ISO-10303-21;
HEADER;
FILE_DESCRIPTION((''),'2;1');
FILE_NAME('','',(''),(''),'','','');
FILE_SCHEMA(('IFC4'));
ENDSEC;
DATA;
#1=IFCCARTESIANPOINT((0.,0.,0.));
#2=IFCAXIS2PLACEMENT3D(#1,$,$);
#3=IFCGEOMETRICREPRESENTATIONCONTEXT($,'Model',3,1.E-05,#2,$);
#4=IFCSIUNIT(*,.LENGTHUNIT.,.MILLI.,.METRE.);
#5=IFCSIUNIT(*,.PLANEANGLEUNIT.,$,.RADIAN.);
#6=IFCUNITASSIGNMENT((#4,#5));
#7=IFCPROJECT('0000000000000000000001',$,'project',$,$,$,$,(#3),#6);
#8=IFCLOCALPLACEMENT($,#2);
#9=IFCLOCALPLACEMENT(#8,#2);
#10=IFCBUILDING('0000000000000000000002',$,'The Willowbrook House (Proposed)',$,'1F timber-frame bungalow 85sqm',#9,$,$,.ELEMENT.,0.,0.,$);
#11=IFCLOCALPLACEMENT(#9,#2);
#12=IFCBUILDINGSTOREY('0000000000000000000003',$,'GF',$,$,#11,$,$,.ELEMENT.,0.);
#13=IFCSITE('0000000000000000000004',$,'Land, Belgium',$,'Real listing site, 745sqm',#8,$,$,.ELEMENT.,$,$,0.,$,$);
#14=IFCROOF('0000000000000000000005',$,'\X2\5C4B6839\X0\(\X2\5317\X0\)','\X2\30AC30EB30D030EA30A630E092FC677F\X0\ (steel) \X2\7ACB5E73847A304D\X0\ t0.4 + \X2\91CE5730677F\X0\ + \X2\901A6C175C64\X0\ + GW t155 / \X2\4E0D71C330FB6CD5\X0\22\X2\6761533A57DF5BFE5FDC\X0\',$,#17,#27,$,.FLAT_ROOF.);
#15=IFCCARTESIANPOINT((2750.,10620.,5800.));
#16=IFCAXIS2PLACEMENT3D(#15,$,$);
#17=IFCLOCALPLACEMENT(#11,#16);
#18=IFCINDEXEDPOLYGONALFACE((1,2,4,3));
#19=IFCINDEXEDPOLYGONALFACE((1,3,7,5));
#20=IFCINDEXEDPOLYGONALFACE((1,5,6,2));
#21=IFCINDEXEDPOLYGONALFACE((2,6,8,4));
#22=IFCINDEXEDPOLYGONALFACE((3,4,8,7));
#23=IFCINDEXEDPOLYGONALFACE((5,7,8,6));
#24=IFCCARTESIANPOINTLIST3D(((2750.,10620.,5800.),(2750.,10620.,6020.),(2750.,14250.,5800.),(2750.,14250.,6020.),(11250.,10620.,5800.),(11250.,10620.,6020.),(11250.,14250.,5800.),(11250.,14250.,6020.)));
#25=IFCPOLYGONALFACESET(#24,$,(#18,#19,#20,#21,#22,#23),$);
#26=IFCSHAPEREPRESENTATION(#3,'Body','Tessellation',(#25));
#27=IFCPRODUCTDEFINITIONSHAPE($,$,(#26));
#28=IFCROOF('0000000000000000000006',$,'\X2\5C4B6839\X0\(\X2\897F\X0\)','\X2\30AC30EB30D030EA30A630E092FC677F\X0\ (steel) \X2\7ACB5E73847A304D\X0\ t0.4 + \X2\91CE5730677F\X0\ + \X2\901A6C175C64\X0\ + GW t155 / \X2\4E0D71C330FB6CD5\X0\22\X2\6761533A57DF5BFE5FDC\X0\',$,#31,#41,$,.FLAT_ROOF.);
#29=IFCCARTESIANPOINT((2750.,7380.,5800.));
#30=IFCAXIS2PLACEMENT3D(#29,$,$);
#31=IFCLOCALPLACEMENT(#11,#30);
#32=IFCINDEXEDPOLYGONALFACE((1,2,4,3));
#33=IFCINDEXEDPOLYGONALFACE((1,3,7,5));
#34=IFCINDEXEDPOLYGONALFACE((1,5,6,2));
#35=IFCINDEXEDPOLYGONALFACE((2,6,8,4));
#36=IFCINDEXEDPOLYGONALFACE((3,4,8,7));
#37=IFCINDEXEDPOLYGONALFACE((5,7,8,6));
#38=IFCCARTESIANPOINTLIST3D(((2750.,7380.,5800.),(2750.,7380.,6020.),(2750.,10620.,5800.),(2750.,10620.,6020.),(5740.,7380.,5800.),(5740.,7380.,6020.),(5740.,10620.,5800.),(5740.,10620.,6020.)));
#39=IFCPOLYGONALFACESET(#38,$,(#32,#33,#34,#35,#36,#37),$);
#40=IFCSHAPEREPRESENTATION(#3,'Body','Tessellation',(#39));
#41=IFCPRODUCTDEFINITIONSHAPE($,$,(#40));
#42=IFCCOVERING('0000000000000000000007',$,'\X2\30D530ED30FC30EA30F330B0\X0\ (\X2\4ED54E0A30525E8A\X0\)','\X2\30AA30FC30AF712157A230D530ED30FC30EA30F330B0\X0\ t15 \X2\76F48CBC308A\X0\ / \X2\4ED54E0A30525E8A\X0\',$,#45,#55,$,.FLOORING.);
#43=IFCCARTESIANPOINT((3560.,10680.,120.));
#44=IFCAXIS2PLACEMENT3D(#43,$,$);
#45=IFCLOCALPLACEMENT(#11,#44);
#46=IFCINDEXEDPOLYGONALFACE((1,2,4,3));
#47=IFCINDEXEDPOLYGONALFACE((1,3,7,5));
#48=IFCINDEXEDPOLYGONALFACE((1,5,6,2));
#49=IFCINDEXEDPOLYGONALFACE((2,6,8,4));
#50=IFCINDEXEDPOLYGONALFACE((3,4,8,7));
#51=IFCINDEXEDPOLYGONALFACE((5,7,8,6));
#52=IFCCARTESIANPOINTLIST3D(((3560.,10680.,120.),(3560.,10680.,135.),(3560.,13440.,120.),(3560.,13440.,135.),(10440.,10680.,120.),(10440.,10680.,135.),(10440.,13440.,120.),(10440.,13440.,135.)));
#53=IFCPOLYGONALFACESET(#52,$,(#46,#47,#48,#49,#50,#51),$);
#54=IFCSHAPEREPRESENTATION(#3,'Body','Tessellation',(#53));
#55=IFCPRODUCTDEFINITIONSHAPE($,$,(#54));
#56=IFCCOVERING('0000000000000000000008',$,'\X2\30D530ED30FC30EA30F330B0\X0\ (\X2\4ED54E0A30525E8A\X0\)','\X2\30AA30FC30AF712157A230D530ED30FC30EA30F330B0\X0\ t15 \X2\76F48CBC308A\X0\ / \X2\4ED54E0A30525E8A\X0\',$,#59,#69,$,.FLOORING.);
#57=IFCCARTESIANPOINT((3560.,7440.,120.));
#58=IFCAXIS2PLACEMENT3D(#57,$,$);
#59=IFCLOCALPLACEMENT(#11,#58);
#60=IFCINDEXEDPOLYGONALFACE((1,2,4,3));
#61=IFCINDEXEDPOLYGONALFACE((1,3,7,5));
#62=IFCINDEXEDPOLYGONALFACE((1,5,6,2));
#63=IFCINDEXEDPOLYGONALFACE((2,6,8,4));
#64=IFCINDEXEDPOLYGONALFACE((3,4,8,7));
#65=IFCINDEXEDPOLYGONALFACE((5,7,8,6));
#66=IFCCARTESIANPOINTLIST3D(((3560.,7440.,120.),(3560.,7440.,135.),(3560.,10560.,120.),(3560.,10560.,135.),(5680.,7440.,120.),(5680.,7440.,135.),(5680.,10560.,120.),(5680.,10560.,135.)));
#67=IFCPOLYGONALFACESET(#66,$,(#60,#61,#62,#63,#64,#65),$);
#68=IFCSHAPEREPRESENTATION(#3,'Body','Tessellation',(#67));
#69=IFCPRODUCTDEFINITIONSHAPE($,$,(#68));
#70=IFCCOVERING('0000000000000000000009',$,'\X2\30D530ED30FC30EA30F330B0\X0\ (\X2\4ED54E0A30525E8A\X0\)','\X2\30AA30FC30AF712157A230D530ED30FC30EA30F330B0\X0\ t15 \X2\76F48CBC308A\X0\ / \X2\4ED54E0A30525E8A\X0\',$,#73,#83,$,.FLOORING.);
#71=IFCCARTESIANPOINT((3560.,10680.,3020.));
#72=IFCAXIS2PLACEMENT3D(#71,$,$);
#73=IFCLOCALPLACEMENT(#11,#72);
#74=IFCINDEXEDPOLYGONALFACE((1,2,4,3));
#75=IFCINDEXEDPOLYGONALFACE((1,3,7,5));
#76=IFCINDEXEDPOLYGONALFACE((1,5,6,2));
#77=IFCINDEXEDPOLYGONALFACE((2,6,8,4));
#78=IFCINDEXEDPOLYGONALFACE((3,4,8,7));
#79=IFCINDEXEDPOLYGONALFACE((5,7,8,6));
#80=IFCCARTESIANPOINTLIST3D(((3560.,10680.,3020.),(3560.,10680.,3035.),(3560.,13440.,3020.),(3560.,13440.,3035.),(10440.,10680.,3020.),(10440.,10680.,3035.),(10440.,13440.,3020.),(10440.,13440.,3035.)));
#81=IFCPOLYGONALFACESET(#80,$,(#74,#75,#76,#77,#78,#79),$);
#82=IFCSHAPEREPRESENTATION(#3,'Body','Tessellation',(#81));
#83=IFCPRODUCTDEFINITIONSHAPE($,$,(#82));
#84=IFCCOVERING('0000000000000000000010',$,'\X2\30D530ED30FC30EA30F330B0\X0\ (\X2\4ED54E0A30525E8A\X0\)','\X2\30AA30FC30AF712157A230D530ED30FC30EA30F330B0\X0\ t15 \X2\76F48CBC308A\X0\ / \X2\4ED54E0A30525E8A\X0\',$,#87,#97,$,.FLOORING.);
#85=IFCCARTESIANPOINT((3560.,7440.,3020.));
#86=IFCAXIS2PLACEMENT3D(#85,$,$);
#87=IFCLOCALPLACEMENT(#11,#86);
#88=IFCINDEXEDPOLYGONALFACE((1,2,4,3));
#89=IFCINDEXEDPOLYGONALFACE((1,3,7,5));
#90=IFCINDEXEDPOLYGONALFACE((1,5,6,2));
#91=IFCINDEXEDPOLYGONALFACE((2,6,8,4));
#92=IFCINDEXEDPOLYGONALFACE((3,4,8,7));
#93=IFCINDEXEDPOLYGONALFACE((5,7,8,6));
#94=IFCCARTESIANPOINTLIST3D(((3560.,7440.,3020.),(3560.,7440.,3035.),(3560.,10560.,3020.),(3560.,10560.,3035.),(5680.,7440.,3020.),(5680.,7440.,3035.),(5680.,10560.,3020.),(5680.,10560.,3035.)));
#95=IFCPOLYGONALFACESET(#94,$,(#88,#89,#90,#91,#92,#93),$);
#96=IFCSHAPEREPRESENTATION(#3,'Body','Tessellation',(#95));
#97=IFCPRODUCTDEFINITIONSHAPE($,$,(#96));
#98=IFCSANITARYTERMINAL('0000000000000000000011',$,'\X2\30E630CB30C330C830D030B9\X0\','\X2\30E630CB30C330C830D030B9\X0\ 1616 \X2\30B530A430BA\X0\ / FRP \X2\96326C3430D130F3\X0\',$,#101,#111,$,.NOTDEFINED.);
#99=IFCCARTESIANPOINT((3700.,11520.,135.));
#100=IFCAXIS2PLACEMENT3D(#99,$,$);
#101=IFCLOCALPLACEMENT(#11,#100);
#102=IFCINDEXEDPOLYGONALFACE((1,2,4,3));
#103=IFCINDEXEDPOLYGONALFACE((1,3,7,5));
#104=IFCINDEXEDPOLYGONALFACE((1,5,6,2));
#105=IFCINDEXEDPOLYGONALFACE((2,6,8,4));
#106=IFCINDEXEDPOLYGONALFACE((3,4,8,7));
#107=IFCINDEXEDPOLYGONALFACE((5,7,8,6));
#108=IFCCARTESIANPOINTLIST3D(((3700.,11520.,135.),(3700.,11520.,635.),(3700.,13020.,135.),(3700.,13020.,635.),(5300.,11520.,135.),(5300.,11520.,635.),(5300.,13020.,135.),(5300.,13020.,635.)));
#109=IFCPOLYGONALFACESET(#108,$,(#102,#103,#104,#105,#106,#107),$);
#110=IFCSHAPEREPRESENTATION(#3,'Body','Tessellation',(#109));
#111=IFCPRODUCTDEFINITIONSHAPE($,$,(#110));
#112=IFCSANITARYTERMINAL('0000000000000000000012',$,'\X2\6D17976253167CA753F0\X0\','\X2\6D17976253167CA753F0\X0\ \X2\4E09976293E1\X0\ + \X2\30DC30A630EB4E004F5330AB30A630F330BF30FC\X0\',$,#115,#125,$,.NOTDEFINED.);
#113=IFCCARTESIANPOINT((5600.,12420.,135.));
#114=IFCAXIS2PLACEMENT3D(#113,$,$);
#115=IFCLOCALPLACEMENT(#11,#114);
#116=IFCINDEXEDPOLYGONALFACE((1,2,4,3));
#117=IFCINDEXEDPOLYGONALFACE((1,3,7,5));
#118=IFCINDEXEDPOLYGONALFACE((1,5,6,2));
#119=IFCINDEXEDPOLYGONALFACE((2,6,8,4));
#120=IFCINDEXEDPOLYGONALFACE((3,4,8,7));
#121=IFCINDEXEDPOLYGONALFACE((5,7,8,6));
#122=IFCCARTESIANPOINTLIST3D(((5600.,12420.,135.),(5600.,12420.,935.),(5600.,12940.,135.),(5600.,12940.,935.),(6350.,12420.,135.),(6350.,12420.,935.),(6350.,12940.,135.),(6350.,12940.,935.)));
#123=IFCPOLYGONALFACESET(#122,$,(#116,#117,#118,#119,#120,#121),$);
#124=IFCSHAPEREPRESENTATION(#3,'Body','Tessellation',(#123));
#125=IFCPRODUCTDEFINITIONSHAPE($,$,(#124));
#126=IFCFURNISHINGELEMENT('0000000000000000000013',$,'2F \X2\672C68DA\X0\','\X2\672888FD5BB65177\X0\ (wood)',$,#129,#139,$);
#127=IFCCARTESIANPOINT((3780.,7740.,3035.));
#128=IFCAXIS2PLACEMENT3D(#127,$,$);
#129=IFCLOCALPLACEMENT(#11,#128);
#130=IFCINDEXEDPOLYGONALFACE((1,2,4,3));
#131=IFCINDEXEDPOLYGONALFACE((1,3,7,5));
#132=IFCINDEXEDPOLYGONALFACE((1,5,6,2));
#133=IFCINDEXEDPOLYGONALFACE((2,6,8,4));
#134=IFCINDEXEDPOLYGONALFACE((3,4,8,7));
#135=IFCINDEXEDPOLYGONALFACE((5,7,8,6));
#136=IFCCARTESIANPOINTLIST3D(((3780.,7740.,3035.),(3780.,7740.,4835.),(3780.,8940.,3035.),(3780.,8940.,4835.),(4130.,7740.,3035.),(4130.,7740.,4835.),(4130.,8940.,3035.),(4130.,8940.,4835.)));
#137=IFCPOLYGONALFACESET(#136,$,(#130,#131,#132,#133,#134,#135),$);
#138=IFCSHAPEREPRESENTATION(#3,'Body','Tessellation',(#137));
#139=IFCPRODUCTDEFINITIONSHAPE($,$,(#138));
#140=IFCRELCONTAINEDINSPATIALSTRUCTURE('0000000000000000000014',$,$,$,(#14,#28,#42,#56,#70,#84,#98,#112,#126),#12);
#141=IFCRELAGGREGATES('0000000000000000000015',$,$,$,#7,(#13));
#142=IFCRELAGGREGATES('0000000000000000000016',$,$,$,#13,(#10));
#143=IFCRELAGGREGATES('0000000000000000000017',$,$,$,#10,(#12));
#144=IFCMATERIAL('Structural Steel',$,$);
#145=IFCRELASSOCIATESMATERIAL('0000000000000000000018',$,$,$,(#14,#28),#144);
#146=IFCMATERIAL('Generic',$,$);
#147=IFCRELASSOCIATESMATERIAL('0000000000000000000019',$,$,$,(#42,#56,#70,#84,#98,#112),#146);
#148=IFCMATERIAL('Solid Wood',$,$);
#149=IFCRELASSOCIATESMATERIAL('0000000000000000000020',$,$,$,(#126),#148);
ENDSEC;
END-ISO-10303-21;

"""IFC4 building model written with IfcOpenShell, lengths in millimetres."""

from ifc_helpers import new_model, si_unit, frame, frame_2d, origin, place, context, project, spatial, rectangle, extrude, material, element, save


model = new_model("IFC4")

# Units and contexts
model_context = context("Model", 3, precision=1e-05, world=origin())
ifc_project = project(units=[si_unit("LENGTHUNIT", "METRE", prefix="MILLI"), si_unit("PLANEANGLEUNIT", "RADIAN")], contexts=[model_context])

# Site, building, storey
site_placement = place(None, origin())
site = spatial("IfcSite", under=ifc_project, at=site_placement, Name="Land, Belgium", ObjectType="Real listing site, 745sqm", CompositionType="ELEMENT", RefElevation=0.0)
building_placement = place(site_placement, origin())
building = spatial("IfcBuilding", under=site, at=building_placement, Name="The Willowbrook House (Proposed)", ObjectType="1F timber-frame bungalow 85sqm", CompositionType="ELEMENT", ElevationOfRefHeight=0.0, ElevationOfTerrain=0.0)
storey_placement = place(building_placement, origin())
storey = spatial("IfcBuildingStorey", under=building, at=storey_placement, Name="GF", CompositionType="ELEMENT", Elevation=0.0)

# Shared definitions
ifc_material_1 = material(Name="Solid Wood")

# Roofs
ifc_material_2 = material(Name="Structural Steel")
for number, where, name in (
    (1, (2750.0, 10620.0, 5800.0), "屋根(北)"),
):
    element("IfcRoof", number, at=place(storey_placement, frame(where)), inside=storey, material=ifc_material_2, Name=name, Description="ガルバリウム鋼板 (steel) 立平葺き t0.4 + 野地板 + 通気層 + GW t155 / 不燃・法22条区域対応", PredefinedType="FLAT_ROOF", context=model_context, shape_type="SweptSolid", body=[
        extrude(rectangle(XDim=8500.0, YDim=3630.0, at=frame_2d((4250.0, 1815.0))), frame((2750.0, 10620.0, 5800.0)), (0.0, 0.0, 1.0), 220.0),
    ])
roof_placement = place(storey_placement, frame((2750.0, 7380.0, 5800.0)))
element("IfcRoof", 2, at=roof_placement, inside=storey, material=ifc_material_2, Name="屋根(西)", Description="ガルバリウム鋼板 (steel) 立平葺き t0.4 + 野地板 + 通気層 + GW t155 / 不燃・法22条区域対応", PredefinedType="FLAT_ROOF", context=model_context, shape_type="SweptSolid", body=[
    extrude(rectangle(XDim=2990.0, YDim=3240.0, at=frame_2d((1495.0, 1620.0))), frame((2750.0, 7380.0, 5800.0)), (0.0, 0.0, 1.0), 220.0),
])

# Coverings
ifc_material_3 = material(Name="Generic")
covering_1_placement = place(storey_placement, frame((3560.0, 10680.0, 120.0)))
element("IfcCovering", 3, at=covering_1_placement, inside=storey, material=ifc_material_3, Name="フローリング (仕上げ床)", Description="オーク無垢フローリング t15 直貼り / 仕上げ床", PredefinedType="FLOORING", context=model_context, shape_type="SweptSolid", body=[
    extrude(rectangle(XDim=6880.0, YDim=2760.0, at=frame_2d((3440.0, 1380.0))), frame((3560.0, 10680.0, 120.0)), (0.0, 0.0, 1.0), 15.0),
])
covering_2_placement = place(storey_placement, frame((3560.0, 7440.0, 120.0)))
element("IfcCovering", 4, at=covering_2_placement, inside=storey, material=ifc_material_3, Name="フローリング (仕上げ床)", Description="オーク無垢フローリング t15 直貼り / 仕上げ床", PredefinedType="FLOORING", context=model_context, shape_type="SweptSolid", body=[
    extrude(rectangle(XDim=2120.0, YDim=3120.0, at=frame_2d((1060.0, 1560.0))), frame((3560.0, 7440.0, 120.0)), (0.0, 0.0, 1.0), 15.0),
])
covering_3_placement = place(storey_placement, frame((3560.0, 10680.0, 3020.0)))
element("IfcCovering", 5, at=covering_3_placement, inside=storey, material=ifc_material_3, Name="フローリング (仕上げ床)", Description="オーク無垢フローリング t15 直貼り / 仕上げ床", PredefinedType="FLOORING", context=model_context, shape_type="SweptSolid", body=[
    extrude(rectangle(XDim=6880.0, YDim=2760.0, at=frame_2d((3440.0, 1380.0))), frame((3560.0, 10680.0, 3020.0)), (0.0, 0.0, 1.0), 15.0),
])
covering_4_placement = place(storey_placement, frame((3560.0, 7440.0, 3020.0)))
element("IfcCovering", 6, at=covering_4_placement, inside=storey, material=ifc_material_3, Name="フローリング (仕上げ床)", Description="オーク無垢フローリング t15 直貼り / 仕上げ床", PredefinedType="FLOORING", context=model_context, shape_type="SweptSolid", body=[
    extrude(rectangle(XDim=2120.0, YDim=3120.0, at=frame_2d((1060.0, 1560.0))), frame((3560.0, 7440.0, 3020.0)), (0.0, 0.0, 1.0), 15.0),
])

# Sanitary terminals
sanitary_terminal_1_placement = place(storey_placement, frame((3700.0, 11520.0, 135.0)))
element("IfcSanitaryTerminal", 7, at=sanitary_terminal_1_placement, inside=storey, material=ifc_material_3, Name="ユニットバス", Description="ユニットバス 1616 サイズ / FRP 防水パン", PredefinedType="NOTDEFINED", context=model_context, shape_type="SweptSolid", body=[
    extrude(rectangle(XDim=1600.0, YDim=1500.0, at=frame_2d((800.0, 750.0))), frame((3700.0, 11520.0, 135.0)), (0.0, 0.0, 1.0), 500.0),
])
sanitary_terminal_2_placement = place(storey_placement, frame((5600.0, 12420.0, 135.0)))
element("IfcSanitaryTerminal", 8, at=sanitary_terminal_2_placement, inside=storey, material=ifc_material_3, Name="洗面化粧台", Description="洗面化粧台 三面鏡 + ボウル一体カウンター", PredefinedType="NOTDEFINED", context=model_context, shape_type="SweptSolid", body=[
    extrude(rectangle(XDim=750.0, YDim=520.0, at=frame_2d((375.0, 260.0))), frame((5600.0, 12420.0, 135.0)), (0.0, 0.0, 1.0), 800.0),
])

# Furnishing element
furnishing_placement = place(storey_placement, frame((3780.0, 7740.0, 3035.0)))
element("IfcFurnishingElement", 9, at=furnishing_placement, inside=storey, material=ifc_material_1, Name="2F 本棚", Description="木製家具 (wood)", context=model_context, shape_type="SweptSolid", body=[
    extrude(rectangle(XDim=350.0, YDim=1200.0, at=frame_2d((175.0, 600.0))), frame((3780.0, 7740.0, 3035.0)), (0.0, 0.0, 1.0), 1800.0),
])

save(model, "model.ifc")
